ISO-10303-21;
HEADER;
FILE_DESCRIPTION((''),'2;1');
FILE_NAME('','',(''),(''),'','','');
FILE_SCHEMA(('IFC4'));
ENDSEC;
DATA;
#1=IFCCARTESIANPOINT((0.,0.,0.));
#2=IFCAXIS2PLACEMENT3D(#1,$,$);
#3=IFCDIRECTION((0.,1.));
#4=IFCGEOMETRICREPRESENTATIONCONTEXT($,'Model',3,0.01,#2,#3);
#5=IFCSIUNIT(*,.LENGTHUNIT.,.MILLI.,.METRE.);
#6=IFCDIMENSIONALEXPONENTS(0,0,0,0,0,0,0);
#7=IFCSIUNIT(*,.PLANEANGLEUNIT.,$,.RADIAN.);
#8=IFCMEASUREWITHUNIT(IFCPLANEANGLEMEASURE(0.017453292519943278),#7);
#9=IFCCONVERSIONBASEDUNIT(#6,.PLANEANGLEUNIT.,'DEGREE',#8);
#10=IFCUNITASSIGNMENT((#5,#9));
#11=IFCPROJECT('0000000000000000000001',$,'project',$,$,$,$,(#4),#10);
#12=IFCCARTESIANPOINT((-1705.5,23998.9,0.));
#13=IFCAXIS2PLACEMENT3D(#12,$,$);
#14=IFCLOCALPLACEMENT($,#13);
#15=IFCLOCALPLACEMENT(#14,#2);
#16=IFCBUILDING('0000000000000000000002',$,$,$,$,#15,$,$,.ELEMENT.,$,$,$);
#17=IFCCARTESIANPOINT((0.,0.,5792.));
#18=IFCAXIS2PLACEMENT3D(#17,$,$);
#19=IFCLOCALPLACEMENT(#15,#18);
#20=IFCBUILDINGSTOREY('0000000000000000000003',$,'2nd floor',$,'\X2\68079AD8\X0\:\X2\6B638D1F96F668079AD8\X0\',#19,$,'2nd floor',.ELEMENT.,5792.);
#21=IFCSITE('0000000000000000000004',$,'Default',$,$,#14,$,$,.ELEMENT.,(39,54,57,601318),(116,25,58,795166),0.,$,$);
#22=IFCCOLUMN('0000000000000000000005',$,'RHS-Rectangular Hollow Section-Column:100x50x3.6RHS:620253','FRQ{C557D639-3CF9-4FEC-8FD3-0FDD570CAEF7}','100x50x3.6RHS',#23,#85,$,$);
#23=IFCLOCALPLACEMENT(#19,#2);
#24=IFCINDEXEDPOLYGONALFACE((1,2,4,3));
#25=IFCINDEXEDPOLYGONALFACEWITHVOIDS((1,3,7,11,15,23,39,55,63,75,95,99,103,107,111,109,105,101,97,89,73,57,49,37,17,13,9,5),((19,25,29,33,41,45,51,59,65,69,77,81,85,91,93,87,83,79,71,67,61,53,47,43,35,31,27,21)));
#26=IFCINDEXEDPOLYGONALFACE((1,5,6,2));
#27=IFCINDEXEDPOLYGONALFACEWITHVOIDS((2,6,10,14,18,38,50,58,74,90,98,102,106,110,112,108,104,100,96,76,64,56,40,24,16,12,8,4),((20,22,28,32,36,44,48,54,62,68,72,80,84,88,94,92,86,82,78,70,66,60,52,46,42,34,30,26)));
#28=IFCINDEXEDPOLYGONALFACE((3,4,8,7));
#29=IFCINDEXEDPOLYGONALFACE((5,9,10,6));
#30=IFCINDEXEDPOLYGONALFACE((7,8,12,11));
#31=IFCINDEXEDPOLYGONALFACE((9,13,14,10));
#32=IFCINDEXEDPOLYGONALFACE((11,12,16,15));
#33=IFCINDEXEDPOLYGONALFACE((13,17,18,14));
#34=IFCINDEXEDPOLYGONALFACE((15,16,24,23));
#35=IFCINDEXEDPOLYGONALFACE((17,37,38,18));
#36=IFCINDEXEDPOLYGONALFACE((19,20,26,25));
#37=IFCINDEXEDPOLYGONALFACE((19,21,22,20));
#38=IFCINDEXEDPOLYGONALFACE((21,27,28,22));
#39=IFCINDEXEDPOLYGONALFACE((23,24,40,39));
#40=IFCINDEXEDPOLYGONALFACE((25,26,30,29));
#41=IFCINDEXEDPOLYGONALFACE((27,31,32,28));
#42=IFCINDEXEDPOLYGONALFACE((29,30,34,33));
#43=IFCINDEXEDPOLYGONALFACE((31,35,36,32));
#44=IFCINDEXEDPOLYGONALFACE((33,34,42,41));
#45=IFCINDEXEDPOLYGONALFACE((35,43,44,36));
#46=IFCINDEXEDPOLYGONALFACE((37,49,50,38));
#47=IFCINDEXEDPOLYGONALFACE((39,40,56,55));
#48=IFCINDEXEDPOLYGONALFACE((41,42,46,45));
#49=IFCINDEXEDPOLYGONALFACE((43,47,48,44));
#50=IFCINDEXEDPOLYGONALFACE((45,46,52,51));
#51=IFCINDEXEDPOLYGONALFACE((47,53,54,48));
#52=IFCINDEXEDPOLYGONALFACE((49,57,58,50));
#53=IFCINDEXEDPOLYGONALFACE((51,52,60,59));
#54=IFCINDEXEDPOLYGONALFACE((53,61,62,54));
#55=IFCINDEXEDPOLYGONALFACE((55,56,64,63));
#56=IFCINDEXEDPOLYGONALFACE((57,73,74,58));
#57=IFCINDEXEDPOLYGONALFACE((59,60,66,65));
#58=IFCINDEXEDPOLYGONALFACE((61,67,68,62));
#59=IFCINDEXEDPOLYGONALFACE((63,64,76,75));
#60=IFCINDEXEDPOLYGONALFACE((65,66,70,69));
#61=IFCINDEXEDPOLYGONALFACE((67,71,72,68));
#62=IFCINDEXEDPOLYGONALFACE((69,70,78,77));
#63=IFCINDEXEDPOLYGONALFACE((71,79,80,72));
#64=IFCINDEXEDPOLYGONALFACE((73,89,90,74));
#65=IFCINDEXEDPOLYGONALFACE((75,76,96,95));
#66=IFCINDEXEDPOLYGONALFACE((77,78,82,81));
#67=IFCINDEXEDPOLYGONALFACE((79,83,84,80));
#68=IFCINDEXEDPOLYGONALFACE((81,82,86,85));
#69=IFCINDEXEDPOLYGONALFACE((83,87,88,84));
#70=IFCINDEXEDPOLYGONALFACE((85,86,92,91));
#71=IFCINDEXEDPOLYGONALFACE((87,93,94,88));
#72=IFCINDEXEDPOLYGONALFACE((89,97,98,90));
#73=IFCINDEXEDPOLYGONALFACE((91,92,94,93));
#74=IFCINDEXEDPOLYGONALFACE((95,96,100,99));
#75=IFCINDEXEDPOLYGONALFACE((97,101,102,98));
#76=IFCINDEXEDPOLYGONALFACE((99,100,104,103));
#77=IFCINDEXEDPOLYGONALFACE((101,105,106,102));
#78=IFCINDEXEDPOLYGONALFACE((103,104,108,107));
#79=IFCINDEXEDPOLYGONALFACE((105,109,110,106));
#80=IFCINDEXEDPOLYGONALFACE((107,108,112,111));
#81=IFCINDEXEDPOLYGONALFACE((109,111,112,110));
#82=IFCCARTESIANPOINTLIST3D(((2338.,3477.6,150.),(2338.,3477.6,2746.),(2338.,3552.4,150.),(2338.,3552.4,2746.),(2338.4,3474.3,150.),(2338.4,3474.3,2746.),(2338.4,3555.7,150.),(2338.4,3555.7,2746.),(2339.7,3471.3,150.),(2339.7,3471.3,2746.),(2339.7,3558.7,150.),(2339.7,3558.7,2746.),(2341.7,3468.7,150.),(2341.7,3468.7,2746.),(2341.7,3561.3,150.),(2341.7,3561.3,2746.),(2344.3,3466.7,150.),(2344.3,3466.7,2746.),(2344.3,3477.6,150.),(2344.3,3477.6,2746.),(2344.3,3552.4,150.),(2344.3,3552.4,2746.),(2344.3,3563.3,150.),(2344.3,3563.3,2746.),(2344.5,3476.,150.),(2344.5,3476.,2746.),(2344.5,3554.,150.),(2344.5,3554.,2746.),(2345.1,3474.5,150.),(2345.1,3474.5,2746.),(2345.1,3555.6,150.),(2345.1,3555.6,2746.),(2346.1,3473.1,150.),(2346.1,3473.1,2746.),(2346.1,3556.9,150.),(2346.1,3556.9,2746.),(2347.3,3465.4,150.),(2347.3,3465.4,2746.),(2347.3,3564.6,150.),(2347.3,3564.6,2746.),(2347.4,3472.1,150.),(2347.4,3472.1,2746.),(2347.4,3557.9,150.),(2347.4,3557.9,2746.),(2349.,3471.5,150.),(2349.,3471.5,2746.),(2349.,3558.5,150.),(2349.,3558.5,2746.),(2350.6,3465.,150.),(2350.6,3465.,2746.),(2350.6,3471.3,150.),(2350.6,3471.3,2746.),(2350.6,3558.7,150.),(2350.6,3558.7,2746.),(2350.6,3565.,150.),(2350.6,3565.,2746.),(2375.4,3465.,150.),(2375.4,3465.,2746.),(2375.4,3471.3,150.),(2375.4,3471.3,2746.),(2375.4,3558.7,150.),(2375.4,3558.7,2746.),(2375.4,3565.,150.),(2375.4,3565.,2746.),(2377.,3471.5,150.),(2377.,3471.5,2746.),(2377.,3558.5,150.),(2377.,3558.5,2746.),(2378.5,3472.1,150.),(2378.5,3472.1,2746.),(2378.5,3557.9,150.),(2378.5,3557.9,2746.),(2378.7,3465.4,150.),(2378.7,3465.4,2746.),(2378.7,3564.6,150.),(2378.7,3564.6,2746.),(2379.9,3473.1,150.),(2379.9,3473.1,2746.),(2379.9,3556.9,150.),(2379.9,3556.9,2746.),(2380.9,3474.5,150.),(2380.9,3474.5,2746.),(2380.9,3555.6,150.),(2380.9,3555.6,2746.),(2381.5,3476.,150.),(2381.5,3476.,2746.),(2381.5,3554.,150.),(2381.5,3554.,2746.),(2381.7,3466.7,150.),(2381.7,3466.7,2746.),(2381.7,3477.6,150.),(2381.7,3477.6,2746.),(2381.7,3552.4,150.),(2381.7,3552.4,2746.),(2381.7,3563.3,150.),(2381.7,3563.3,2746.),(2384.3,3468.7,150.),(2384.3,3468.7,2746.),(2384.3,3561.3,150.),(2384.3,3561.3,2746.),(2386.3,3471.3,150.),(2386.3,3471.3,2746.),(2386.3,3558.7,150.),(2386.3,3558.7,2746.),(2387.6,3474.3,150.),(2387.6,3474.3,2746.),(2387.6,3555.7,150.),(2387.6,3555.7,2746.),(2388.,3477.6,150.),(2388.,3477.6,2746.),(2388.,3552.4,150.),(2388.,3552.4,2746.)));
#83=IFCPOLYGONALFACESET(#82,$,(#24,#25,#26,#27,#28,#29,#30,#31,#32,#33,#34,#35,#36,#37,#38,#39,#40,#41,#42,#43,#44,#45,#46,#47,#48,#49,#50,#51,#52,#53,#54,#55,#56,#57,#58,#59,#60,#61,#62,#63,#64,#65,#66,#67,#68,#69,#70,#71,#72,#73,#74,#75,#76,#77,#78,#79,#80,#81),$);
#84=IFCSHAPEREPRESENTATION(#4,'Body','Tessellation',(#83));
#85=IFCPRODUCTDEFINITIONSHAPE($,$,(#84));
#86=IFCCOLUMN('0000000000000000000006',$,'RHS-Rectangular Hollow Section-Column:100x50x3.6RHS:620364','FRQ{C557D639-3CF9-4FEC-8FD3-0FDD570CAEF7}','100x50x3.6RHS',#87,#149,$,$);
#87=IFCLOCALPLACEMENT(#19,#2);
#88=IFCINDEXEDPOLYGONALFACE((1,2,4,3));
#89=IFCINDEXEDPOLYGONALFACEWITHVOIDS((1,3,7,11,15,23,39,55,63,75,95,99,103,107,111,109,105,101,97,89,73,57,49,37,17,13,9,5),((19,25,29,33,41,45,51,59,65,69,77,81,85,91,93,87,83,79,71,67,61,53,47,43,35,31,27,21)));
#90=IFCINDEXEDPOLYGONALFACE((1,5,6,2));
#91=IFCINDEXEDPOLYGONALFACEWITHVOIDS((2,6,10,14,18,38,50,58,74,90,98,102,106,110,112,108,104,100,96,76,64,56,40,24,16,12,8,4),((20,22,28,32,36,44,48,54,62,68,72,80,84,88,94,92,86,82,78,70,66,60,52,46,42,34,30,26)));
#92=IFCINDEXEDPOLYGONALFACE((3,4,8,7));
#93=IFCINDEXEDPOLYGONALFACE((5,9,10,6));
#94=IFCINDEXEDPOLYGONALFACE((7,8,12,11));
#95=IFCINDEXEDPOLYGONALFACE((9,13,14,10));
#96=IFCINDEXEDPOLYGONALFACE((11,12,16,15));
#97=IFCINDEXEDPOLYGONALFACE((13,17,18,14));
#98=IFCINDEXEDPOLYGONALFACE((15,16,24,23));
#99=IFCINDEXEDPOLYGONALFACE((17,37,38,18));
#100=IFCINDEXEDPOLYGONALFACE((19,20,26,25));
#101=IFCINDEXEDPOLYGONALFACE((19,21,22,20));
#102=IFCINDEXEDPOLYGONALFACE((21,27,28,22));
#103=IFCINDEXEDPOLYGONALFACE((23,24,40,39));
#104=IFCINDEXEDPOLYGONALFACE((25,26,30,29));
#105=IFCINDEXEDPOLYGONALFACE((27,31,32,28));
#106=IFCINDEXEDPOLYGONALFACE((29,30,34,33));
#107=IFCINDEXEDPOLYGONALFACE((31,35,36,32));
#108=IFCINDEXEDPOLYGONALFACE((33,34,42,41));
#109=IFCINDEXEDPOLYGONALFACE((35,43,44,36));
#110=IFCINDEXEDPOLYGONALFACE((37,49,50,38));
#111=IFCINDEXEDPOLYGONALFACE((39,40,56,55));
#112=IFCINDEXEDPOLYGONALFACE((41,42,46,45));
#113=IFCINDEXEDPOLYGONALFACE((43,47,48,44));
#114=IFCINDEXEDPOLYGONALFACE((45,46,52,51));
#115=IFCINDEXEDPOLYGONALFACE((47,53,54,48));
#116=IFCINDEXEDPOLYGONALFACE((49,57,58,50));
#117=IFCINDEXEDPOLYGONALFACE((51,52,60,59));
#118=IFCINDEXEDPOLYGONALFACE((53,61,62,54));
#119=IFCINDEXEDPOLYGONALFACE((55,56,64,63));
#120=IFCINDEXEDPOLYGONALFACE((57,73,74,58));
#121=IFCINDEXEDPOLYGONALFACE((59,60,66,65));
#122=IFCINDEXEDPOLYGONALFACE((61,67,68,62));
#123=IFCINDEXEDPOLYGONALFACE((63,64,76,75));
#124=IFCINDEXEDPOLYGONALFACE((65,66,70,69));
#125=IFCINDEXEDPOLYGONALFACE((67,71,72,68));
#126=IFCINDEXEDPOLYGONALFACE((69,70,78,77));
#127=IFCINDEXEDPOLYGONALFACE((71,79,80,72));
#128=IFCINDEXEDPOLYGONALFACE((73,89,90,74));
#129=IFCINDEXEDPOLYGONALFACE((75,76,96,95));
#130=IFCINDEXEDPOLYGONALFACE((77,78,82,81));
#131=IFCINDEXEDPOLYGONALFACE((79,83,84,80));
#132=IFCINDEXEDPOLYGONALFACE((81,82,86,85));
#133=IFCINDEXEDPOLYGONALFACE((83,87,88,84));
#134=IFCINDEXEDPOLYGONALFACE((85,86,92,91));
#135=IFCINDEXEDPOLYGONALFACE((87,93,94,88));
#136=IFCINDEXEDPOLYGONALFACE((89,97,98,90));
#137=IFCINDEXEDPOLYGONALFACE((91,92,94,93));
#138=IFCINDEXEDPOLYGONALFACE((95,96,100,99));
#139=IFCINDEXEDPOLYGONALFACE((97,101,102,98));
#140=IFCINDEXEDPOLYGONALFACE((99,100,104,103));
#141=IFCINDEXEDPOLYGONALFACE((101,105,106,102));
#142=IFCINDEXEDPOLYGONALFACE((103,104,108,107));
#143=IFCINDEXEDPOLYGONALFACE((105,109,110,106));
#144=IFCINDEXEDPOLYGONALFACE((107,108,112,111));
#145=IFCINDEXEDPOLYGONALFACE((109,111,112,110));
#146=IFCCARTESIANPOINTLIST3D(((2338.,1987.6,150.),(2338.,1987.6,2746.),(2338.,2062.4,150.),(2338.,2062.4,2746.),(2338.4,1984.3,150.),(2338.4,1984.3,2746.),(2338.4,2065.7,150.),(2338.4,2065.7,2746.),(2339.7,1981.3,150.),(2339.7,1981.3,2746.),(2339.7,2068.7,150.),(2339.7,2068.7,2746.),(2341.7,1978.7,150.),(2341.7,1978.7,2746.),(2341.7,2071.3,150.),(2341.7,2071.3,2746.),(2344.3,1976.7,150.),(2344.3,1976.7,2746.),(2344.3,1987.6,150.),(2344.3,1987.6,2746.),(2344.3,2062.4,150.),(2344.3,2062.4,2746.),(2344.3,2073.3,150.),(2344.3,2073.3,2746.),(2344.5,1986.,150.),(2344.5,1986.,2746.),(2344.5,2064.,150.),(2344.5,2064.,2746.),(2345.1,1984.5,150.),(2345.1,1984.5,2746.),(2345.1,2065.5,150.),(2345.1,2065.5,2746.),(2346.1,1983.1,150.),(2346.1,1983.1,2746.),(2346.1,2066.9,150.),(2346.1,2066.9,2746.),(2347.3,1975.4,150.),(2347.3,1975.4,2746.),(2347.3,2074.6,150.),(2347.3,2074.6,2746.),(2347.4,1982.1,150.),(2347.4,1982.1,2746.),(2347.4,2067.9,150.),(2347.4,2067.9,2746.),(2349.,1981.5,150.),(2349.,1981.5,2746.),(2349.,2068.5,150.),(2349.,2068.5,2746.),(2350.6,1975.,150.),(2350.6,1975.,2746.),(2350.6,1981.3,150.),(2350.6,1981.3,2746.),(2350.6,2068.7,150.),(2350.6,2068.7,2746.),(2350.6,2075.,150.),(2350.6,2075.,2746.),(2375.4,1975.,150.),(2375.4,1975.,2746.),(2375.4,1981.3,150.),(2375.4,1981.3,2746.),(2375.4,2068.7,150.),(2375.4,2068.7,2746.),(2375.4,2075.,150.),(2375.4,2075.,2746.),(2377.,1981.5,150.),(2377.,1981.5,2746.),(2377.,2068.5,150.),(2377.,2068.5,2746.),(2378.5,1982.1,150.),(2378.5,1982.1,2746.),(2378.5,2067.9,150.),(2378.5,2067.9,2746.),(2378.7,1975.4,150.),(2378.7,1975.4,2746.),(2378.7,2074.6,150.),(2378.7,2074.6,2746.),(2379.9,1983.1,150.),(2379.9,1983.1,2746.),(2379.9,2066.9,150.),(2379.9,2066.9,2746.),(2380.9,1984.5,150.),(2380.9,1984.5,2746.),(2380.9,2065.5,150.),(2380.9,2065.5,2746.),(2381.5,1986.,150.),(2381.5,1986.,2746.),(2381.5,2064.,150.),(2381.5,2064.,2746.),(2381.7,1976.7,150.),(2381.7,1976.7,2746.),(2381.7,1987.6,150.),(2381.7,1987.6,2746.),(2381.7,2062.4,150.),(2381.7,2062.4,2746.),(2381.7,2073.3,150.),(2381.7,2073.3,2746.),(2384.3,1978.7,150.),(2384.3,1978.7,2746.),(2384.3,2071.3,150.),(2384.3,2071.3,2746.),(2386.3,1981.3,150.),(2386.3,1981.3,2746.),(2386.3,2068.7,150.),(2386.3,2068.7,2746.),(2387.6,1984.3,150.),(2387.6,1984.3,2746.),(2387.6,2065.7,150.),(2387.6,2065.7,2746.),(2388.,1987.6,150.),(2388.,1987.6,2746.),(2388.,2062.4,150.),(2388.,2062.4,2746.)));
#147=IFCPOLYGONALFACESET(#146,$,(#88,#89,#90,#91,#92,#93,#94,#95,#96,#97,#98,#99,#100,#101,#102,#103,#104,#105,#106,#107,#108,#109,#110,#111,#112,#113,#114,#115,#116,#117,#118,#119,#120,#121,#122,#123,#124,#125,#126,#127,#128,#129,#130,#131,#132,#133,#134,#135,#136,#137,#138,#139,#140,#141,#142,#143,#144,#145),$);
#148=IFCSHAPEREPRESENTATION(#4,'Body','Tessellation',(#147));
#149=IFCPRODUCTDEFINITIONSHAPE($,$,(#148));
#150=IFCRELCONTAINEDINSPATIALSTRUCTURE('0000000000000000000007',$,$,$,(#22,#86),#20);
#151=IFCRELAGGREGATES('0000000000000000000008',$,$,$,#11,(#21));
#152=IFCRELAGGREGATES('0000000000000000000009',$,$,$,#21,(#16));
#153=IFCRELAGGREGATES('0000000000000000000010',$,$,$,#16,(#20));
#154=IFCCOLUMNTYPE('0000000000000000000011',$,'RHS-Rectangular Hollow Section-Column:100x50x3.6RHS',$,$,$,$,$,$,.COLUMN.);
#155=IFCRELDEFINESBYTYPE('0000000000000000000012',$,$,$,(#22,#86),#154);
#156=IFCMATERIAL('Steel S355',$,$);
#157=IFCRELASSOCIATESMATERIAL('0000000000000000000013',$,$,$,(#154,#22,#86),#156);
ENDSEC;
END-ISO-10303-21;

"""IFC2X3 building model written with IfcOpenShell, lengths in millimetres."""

from ifc_helpers import new_model, entity, si_unit, converted_unit, direction, frame, origin, origin_2d, place, context, project, spatial, hollow_rectangle, extrude, clip, halfspace, material, type_object, element, save


model = new_model("IFC2X3")

# Units and contexts
model_context = context("Model", 3, precision=0.01, world=origin(), true_north=direction((0.0, 1.0)))
ifc_project = project(units=[si_unit("LENGTHUNIT", "METRE", prefix="MILLI"), converted_unit("PLANEANGLEUNIT", "DEGREE", entity("IfcPlaneAngleMeasure", 0.017453292519943278), si_unit("PLANEANGLEUNIT", "RADIAN"), dimensions=[0, 0, 0, 0, 0, 0, 0])], contexts=[model_context])

# Site, building, storey
site_placement = place(None, frame((-1705.5, 23998.9, 0.0)))
site = spatial("IfcSite", under=ifc_project, at=site_placement, Name="Default", CompositionType="ELEMENT", RefLatitude=(39, 54, 57, 601318), RefLongitude=(116, 25, 58, 795166), RefElevation=0.0)
building_placement = place(site_placement, origin())
building = spatial("IfcBuilding", under=site, at=building_placement, CompositionType="ELEMENT")
storey_placement = place(building_placement, frame((0.0, 0.0, 5792.0)))
storey = spatial("IfcBuildingStorey", under=building, at=storey_placement, Name="2nd floor", ObjectType="标高:正负零标高", LongName="2nd floor", CompositionType="ELEMENT", Elevation=5792.0)

# Columns
ifc_material_1 = material(Name="Steel S355")
column_type_1 = type_object("IfcColumnType", Name="RHS-Rectangular Hollow Section-Column:100x50x3.6RHS", PredefinedType="COLUMN", material=ifc_material_1)
column_1_placement = place(storey_placement, frame((2363.0, 3515.0, 2746.0), z_axis=(0.0, 0.0, 1.0), x_axis=(-1.0, 0.0, 0.0)))
element("IfcColumn", 1, at=column_1_placement, inside=storey, type_object=column_type_1, material=ifc_material_1, Name="RHS-Rectangular Hollow Section-Column:100x50x3.6RHS:620253", Description="FRQ{C557D639-3CF9-4FEC-8FD3-0FDD570CAEF7}", ObjectType="100x50x3.6RHS", context=model_context, shape_type="Clipping", body=[
    clip(extrude(hollow_rectangle(XDim=50.0, YDim=100.0, WallThickness=6.3, InnerFilletRadius=6.3, OuterFilletRadius=12.6, at=origin_2d()), origin(), (0.0, 0.0, -1.0), 2651.9), halfspace(frame((2363.0, 3515.0, -2596.0), z_axis=(0.0, 0.0, 1.0), x_axis=(-1.0, 0.0, 0.0)), True)),
])
column_2_placement = place(storey_placement, frame((2363.0, 2025.0, 2746.0), z_axis=(0.0, 0.0, 1.0), x_axis=(-1.0, 0.0, 0.0)))
element("IfcColumn", 2, at=column_2_placement, inside=storey, type_object=column_type_1, material=ifc_material_1, Name="RHS-Rectangular Hollow Section-Column:100x50x3.6RHS:620364", Description="FRQ{C557D639-3CF9-4FEC-8FD3-0FDD570CAEF7}", ObjectType="100x50x3.6RHS", context=model_context, shape_type="Clipping", body=[
    clip(extrude(hollow_rectangle(XDim=50.0, YDim=100.0, WallThickness=6.3, InnerFilletRadius=6.3, OuterFilletRadius=12.6, at=origin_2d()), origin(), (0.0, 0.0, -1.0), 2651.9), halfspace(frame((2363.0, 2025.0, -2596.0), z_axis=(0.0, 0.0, 1.0), x_axis=(-1.0, 0.0, 0.0)), True)),
])

save(model, "model.ifc")
